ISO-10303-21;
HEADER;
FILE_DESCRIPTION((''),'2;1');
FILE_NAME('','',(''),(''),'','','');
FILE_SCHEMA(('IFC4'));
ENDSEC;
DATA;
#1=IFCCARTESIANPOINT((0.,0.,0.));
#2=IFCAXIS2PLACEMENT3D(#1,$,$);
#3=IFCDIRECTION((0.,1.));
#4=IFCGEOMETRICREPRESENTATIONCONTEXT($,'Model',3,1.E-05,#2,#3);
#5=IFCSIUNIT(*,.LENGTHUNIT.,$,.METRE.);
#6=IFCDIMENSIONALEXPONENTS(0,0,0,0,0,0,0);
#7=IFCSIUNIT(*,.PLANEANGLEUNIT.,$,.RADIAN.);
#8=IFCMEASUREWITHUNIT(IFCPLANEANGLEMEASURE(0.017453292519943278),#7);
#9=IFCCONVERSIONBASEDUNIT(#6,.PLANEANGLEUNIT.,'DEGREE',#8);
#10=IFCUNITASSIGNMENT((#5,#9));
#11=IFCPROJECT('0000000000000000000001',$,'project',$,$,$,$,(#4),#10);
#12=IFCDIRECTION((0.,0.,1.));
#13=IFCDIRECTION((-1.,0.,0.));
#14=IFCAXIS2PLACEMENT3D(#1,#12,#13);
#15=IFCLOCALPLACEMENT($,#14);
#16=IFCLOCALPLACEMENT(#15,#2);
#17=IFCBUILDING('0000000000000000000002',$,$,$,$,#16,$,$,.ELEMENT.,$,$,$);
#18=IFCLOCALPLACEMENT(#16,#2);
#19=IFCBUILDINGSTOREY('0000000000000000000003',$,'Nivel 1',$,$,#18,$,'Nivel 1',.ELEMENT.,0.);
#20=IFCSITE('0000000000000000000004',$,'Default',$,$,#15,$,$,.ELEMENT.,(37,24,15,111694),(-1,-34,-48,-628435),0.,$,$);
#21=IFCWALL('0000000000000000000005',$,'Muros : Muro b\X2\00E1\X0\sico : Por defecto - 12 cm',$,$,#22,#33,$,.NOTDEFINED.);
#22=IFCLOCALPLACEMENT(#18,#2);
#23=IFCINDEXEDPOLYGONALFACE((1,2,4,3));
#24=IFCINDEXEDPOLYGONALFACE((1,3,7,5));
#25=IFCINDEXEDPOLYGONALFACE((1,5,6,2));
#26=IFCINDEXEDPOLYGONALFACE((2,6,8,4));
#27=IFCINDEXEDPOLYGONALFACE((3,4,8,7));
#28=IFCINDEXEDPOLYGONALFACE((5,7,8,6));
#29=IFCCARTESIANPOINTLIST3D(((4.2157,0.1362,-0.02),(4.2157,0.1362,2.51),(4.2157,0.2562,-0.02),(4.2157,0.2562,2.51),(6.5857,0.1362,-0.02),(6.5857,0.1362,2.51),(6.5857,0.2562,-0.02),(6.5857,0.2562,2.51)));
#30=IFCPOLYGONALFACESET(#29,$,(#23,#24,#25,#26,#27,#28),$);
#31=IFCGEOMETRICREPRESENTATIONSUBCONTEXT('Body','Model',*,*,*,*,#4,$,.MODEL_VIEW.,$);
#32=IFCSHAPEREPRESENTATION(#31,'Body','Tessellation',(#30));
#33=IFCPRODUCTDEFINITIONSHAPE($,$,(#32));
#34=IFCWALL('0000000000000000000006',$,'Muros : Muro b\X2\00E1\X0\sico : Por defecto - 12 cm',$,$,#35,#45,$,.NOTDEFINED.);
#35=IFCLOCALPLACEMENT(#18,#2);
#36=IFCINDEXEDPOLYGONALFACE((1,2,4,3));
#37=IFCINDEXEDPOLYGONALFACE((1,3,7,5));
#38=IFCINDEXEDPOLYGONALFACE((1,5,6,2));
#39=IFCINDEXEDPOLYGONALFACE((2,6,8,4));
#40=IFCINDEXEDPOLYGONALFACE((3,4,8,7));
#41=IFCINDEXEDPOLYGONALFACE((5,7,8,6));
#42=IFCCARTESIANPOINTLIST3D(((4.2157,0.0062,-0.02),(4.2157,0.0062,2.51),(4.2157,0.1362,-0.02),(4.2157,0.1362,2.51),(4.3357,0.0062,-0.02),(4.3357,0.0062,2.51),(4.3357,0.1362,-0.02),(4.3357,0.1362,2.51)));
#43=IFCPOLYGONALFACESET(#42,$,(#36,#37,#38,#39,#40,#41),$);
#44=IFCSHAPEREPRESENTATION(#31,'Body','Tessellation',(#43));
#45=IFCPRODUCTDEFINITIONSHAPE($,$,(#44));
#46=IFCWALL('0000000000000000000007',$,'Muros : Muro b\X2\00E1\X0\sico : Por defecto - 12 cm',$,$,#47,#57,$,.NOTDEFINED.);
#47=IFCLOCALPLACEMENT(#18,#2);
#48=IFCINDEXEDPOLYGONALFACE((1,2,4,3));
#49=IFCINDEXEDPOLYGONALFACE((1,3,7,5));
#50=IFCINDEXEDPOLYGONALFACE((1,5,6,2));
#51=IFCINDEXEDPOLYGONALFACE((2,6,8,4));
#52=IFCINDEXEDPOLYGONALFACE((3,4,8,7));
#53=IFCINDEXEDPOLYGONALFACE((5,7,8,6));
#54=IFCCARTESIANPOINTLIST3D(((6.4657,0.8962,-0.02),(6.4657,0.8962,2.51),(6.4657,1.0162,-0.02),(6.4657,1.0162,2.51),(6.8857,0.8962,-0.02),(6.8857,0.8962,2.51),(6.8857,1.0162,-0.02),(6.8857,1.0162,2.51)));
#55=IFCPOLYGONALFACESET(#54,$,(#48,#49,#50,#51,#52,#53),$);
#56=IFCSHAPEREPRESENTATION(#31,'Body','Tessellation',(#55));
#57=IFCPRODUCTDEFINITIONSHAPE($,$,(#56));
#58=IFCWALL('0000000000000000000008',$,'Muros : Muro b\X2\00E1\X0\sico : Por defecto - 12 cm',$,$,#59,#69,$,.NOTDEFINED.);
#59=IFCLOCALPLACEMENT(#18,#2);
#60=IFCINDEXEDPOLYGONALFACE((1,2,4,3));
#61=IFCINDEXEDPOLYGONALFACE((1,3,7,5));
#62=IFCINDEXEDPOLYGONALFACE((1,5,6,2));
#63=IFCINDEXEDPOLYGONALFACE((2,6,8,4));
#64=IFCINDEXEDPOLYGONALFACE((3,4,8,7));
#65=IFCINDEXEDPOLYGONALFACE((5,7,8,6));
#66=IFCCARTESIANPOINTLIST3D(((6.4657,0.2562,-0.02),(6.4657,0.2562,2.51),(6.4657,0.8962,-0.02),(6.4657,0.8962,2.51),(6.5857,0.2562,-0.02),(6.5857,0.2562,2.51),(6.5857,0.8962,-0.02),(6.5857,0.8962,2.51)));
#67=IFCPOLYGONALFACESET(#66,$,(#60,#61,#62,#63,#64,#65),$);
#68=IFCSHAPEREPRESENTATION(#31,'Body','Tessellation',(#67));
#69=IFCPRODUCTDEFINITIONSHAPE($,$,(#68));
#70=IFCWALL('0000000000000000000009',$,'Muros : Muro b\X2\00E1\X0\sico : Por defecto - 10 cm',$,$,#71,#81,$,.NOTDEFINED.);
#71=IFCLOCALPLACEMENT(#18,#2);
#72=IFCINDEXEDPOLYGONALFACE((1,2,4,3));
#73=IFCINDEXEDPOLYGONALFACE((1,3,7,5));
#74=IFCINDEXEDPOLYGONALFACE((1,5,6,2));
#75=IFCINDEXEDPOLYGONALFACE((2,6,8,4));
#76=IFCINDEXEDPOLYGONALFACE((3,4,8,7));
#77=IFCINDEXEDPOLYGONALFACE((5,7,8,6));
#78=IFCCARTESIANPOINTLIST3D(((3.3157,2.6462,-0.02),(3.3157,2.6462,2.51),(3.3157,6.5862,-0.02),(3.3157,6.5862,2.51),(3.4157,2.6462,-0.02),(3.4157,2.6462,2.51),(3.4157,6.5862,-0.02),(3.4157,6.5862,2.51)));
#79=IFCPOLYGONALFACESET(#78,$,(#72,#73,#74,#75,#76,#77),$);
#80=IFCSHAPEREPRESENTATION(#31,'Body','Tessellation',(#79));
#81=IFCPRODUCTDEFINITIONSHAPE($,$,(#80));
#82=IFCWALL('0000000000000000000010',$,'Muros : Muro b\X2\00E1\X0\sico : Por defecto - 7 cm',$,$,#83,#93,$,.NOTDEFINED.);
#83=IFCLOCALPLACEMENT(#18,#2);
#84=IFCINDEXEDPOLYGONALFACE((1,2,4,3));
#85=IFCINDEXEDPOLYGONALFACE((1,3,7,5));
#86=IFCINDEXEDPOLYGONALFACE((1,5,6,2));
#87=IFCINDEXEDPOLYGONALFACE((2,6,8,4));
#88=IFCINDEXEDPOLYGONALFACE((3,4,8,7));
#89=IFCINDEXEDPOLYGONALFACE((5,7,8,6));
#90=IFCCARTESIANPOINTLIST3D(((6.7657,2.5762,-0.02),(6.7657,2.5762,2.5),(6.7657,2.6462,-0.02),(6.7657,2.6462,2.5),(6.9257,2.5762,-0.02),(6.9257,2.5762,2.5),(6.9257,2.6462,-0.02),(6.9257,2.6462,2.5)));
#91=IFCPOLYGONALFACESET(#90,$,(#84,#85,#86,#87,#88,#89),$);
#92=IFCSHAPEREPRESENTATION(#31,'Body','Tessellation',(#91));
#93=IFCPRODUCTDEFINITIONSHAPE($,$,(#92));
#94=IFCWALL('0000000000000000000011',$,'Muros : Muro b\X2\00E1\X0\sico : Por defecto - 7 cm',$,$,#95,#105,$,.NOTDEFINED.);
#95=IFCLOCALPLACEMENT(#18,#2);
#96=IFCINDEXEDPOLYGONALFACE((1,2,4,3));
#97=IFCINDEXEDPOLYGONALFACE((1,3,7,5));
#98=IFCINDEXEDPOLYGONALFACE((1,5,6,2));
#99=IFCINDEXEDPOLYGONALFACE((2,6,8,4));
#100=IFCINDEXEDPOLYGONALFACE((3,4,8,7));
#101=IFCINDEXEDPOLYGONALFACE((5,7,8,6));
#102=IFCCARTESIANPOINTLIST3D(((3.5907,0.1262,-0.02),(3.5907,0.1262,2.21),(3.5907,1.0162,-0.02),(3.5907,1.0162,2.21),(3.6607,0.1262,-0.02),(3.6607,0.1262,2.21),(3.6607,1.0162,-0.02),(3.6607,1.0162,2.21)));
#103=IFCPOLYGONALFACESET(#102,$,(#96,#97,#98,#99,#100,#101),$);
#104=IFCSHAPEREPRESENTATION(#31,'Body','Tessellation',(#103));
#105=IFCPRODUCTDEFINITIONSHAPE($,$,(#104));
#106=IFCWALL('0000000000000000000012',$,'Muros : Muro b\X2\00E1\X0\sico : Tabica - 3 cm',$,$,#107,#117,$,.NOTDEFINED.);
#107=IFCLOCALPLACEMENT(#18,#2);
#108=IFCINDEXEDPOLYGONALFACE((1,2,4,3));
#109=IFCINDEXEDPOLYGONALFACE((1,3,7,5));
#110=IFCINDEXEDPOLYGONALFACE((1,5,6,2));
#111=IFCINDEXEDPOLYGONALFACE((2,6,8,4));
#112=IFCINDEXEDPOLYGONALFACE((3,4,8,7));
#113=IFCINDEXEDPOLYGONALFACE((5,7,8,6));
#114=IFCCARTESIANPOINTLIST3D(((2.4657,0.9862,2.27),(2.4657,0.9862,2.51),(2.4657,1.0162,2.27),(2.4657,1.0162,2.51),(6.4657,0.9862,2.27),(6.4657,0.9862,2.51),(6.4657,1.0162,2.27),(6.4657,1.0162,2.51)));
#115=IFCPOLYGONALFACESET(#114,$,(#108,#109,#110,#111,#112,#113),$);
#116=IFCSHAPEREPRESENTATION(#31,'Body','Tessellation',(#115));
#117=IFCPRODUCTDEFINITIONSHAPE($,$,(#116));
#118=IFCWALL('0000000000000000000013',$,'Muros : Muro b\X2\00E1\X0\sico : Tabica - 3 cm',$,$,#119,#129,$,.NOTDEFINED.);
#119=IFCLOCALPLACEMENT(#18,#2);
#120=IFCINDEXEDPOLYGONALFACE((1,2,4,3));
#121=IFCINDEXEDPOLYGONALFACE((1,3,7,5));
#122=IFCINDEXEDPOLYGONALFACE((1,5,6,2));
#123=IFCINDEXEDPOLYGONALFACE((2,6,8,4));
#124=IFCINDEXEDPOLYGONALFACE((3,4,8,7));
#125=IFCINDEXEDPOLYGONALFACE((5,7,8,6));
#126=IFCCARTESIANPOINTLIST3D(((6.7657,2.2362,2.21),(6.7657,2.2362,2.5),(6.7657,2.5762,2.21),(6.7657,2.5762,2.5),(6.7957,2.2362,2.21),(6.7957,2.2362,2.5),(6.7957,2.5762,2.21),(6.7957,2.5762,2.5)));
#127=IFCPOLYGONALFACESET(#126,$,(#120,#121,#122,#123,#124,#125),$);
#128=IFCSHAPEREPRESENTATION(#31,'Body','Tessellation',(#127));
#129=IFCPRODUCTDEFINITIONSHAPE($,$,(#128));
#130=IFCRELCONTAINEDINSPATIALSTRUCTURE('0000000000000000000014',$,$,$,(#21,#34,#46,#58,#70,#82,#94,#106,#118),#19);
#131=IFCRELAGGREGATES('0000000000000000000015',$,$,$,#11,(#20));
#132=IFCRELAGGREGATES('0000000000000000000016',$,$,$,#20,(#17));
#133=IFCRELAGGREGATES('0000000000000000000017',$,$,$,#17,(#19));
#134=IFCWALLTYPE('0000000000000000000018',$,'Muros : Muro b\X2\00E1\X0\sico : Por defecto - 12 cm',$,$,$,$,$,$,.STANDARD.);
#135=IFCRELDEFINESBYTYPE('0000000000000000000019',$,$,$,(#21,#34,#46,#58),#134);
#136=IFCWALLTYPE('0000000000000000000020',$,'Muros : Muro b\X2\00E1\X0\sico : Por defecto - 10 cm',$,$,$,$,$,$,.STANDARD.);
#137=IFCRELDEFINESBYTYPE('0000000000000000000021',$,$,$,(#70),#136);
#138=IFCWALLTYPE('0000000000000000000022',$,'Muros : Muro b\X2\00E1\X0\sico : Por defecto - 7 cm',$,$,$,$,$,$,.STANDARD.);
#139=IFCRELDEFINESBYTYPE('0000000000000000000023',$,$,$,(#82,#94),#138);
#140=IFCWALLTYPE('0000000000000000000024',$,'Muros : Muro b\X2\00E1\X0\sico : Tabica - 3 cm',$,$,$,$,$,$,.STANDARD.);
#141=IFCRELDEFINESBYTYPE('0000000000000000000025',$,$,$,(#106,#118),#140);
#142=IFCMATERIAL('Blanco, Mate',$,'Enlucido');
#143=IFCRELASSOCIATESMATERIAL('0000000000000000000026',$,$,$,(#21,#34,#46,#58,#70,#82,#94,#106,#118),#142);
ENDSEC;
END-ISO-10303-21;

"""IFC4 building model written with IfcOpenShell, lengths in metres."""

from ifc_helpers import new_model, entity, si_unit, converted_unit, direction, frame, origin, place, context, subcontext, project, spatial, indexed_curve, outline, extrude, material, type_object, element, save


model = new_model("IFC4")

# Units and contexts
model_context = context("Model", 3, precision=1e-05, world=origin(), true_north=direction((0.0, 1.0)))
body_context = subcontext(model_context, "Body", "Model", "MODEL_VIEW")
ifc_project = project(units=[si_unit("LENGTHUNIT", "METRE"), converted_unit("PLANEANGLEUNIT", "DEGREE", entity("IfcPlaneAngleMeasure", 0.017453292519943278), si_unit("PLANEANGLEUNIT", "RADIAN"), dimensions=[0, 0, 0, 0, 0, 0, 0])], contexts=[model_context])

# Site, building, storey
site_placement = place(None, frame((0.0, 0.0, 0.0), z_axis=(0.0, 0.0, 1.0), x_axis=(-1.0, 0.0, 0.0)))
site = spatial("IfcSite", under=ifc_project, at=site_placement, Name="Default", CompositionType="ELEMENT", RefLatitude=(37, 24, 15, 111694), RefLongitude=(-1, -34, -48, -628435), RefElevation=0.0)
building_placement = place(site_placement, origin())
building = spatial("IfcBuilding", under=site, at=building_placement, CompositionType="ELEMENT")
storey_placement = place(building_placement, origin())
storey = spatial("IfcBuildingStorey", under=building, at=storey_placement, Name="Nivel 1", LongName="Nivel 1", CompositionType="ELEMENT", Elevation=0.0)

# Walls
ifc_material_1 = material(Name="Blanco, Mate", Category="Enlucido")
wall_type_1 = type_object("IfcWallType", Name="Muros : Muro básico : Por defecto - 12 cm", PredefinedType="STANDARD")
wall_1_placement = place(storey_placement, frame((6.5857, 0.1962, -0.02), z_axis=(0.0, 0.0, 1.0), x_axis=(-1.0, 0.0, 0.0)))
element("IfcWall", 1, at=wall_1_placement, inside=storey, type_object=wall_type_1, material=ifc_material_1, Name="Muros : Muro básico : Por defecto - 12 cm", PredefinedType="NOTDEFINED", context=body_context, shape_type="SweptSolid", body=[
    extrude(outline(indexed_curve([(2.37, 0.06), (0.0, 0.06), (0.0, -0.06), (2.37, -0.06), (2.37, 0.06)], self_intersect=False)), origin(), (0.0, 0.0, 1.0), 2.53),
])
wall_2_placement = place(storey_placement, frame((4.2757, 0.1362, -0.02), z_axis=(0.0, 0.0, 1.0), x_axis=(0.0, -1.0, 0.0)))
element("IfcWall", 2, at=wall_2_placement, inside=storey, type_object=wall_type_1, material=ifc_material_1, Name="Muros : Muro básico : Por defecto - 12 cm", PredefinedType="NOTDEFINED", context=body_context, shape_type="SweptSolid", body=[
    extrude(outline(indexed_curve([(0.13, 0.06), (0.0, 0.06), (0.0, -0.06), (0.13, -0.06), (0.13, 0.06)], self_intersect=False)), origin(), (0.0, 0.0, 1.0), 2.53),
])
wall_3_placement = place(storey_placement, frame((6.8857, 0.9562, -0.02), z_axis=(0.0, 0.0, 1.0), x_axis=(-1.0, 0.0, 0.0)))
element("IfcWall", 3, at=wall_3_placement, inside=storey, type_object=wall_type_1, material=ifc_material_1, Name="Muros : Muro básico : Por defecto - 12 cm", PredefinedType="NOTDEFINED", context=body_context, shape_type="SweptSolid", body=[
    extrude(outline(indexed_curve([(0.42, 0.06), (0.0, 0.06), (0.0, -0.06), (0.42, -0.06), (0.42, 0.06)], self_intersect=False)), origin(), (0.0, 0.0, 1.0), 2.53),
])
wall_4_placement = place(storey_placement, frame((6.5257, 0.8962, -0.02), z_axis=(0.0, 0.0, 1.0), x_axis=(0.0, -1.0, 0.0)))
element("IfcWall", 4, at=wall_4_placement, inside=storey, type_object=wall_type_1, material=ifc_material_1, Name="Muros : Muro básico : Por defecto - 12 cm", PredefinedType="NOTDEFINED", context=body_context, shape_type="SweptSolid", body=[
    extrude(outline(indexed_curve([(0.64, 0.06), (0.0, 0.06), (0.0, -0.06), (0.64, -0.06), (0.64, 0.06)], self_intersect=False)), origin(), (0.0, 0.0, 1.0), 2.53),
])
wall_type_2 = type_object("IfcWallType", Name="Muros : Muro básico : Por defecto - 10 cm", PredefinedType="STANDARD")
wall_5_placement = place(storey_placement, frame((3.3657, 2.6462, -0.02), z_axis=(0.0, 0.0, 1.0), x_axis=(0.0, 1.0, 0.0)))
element("IfcWall", 5, at=wall_5_placement, inside=storey, type_object=wall_type_2, material=ifc_material_1, Name="Muros : Muro básico : Por defecto - 10 cm", PredefinedType="NOTDEFINED", context=body_context, shape_type="SweptSolid", body=[
    extrude(outline(indexed_curve([(3.94, 0.05), (0.0, 0.05), (0.0, -0.05), (3.94, -0.05), (3.94, 0.05)], self_intersect=False)), origin(), (0.0, 0.0, 1.0), 2.53),
])
wall_type_3 = type_object("IfcWallType", Name="Muros : Muro básico : Por defecto - 7 cm", PredefinedType="STANDARD")
wall_6_placement = place(storey_placement, frame((6.9257, 2.6112, -0.02), z_axis=(0.0, 0.0, 1.0), x_axis=(-1.0, 0.0, 0.0)))
element("IfcWall", 6, at=wall_6_placement, inside=storey, type_object=wall_type_3, material=ifc_material_1, Name="Muros : Muro básico : Por defecto - 7 cm", PredefinedType="NOTDEFINED", context=body_context, shape_type="SweptSolid", body=[
    extrude(outline(indexed_curve([(0.16, 0.035), (0.0, 0.035), (0.0, -0.035), (0.16, -0.035), (0.16, 0.035)], self_intersect=False)), origin(), (0.0, 0.0, 1.0), 2.52),
])
wall_7_placement = place(storey_placement, frame((3.6257, 0.1262, -0.02), z_axis=(0.0, 0.0, 1.0), x_axis=(0.0, 1.0, 0.0)))
element("IfcWall", 7, at=wall_7_placement, inside=storey, type_object=wall_type_3, material=ifc_material_1, Name="Muros : Muro básico : Por defecto - 7 cm", PredefinedType="NOTDEFINED", context=body_context, shape_type="SweptSolid", body=[
    extrude(outline(indexed_curve([(0.89, 0.035), (0.0, 0.035), (0.0, -0.035), (0.89, -0.035), (0.89, 0.035)], self_intersect=False)), origin(), (0.0, 0.0, 1.0), 2.23),
])
wall_type_4 = type_object("IfcWallType", Name="Muros : Muro básico : Tabica - 3 cm", PredefinedType="STANDARD")
wall_8_placement = place(storey_placement, frame((2.4657, 1.0012, 2.27)))
element("IfcWall", 8, at=wall_8_placement, inside=storey, type_object=wall_type_4, material=ifc_material_1, Name="Muros : Muro básico : Tabica - 3 cm", PredefinedType="NOTDEFINED", context=body_context, shape_type="SweptSolid", body=[
    extrude(outline(indexed_curve([(4.0, 0.015), (0.0, 0.015), (0.0, -0.015), (4.0, -0.015), (4.0, 0.015)], self_intersect=False)), origin(), (0.0, 0.0, 1.0), 0.24),
])
wall_9_placement = place(storey_placement, frame((6.7807, 2.2362, 2.21), z_axis=(0.0, 0.0, 1.0), x_axis=(0.0, 1.0, 0.0)))
element("IfcWall", 9, at=wall_9_placement, inside=storey, type_object=wall_type_4, material=ifc_material_1, Name="Muros : Muro básico : Tabica - 3 cm", PredefinedType="NOTDEFINED", context=body_context, shape_type="SweptSolid", body=[
    extrude(outline(indexed_curve([(0.34, 0.015), (0.0, 0.015), (0.0, -0.015), (0.34, -0.015), (0.34, 0.015)], self_intersect=False)), origin(), (0.0, 0.0, 1.0), 0.29),
])

save(model, "model.ifc")
